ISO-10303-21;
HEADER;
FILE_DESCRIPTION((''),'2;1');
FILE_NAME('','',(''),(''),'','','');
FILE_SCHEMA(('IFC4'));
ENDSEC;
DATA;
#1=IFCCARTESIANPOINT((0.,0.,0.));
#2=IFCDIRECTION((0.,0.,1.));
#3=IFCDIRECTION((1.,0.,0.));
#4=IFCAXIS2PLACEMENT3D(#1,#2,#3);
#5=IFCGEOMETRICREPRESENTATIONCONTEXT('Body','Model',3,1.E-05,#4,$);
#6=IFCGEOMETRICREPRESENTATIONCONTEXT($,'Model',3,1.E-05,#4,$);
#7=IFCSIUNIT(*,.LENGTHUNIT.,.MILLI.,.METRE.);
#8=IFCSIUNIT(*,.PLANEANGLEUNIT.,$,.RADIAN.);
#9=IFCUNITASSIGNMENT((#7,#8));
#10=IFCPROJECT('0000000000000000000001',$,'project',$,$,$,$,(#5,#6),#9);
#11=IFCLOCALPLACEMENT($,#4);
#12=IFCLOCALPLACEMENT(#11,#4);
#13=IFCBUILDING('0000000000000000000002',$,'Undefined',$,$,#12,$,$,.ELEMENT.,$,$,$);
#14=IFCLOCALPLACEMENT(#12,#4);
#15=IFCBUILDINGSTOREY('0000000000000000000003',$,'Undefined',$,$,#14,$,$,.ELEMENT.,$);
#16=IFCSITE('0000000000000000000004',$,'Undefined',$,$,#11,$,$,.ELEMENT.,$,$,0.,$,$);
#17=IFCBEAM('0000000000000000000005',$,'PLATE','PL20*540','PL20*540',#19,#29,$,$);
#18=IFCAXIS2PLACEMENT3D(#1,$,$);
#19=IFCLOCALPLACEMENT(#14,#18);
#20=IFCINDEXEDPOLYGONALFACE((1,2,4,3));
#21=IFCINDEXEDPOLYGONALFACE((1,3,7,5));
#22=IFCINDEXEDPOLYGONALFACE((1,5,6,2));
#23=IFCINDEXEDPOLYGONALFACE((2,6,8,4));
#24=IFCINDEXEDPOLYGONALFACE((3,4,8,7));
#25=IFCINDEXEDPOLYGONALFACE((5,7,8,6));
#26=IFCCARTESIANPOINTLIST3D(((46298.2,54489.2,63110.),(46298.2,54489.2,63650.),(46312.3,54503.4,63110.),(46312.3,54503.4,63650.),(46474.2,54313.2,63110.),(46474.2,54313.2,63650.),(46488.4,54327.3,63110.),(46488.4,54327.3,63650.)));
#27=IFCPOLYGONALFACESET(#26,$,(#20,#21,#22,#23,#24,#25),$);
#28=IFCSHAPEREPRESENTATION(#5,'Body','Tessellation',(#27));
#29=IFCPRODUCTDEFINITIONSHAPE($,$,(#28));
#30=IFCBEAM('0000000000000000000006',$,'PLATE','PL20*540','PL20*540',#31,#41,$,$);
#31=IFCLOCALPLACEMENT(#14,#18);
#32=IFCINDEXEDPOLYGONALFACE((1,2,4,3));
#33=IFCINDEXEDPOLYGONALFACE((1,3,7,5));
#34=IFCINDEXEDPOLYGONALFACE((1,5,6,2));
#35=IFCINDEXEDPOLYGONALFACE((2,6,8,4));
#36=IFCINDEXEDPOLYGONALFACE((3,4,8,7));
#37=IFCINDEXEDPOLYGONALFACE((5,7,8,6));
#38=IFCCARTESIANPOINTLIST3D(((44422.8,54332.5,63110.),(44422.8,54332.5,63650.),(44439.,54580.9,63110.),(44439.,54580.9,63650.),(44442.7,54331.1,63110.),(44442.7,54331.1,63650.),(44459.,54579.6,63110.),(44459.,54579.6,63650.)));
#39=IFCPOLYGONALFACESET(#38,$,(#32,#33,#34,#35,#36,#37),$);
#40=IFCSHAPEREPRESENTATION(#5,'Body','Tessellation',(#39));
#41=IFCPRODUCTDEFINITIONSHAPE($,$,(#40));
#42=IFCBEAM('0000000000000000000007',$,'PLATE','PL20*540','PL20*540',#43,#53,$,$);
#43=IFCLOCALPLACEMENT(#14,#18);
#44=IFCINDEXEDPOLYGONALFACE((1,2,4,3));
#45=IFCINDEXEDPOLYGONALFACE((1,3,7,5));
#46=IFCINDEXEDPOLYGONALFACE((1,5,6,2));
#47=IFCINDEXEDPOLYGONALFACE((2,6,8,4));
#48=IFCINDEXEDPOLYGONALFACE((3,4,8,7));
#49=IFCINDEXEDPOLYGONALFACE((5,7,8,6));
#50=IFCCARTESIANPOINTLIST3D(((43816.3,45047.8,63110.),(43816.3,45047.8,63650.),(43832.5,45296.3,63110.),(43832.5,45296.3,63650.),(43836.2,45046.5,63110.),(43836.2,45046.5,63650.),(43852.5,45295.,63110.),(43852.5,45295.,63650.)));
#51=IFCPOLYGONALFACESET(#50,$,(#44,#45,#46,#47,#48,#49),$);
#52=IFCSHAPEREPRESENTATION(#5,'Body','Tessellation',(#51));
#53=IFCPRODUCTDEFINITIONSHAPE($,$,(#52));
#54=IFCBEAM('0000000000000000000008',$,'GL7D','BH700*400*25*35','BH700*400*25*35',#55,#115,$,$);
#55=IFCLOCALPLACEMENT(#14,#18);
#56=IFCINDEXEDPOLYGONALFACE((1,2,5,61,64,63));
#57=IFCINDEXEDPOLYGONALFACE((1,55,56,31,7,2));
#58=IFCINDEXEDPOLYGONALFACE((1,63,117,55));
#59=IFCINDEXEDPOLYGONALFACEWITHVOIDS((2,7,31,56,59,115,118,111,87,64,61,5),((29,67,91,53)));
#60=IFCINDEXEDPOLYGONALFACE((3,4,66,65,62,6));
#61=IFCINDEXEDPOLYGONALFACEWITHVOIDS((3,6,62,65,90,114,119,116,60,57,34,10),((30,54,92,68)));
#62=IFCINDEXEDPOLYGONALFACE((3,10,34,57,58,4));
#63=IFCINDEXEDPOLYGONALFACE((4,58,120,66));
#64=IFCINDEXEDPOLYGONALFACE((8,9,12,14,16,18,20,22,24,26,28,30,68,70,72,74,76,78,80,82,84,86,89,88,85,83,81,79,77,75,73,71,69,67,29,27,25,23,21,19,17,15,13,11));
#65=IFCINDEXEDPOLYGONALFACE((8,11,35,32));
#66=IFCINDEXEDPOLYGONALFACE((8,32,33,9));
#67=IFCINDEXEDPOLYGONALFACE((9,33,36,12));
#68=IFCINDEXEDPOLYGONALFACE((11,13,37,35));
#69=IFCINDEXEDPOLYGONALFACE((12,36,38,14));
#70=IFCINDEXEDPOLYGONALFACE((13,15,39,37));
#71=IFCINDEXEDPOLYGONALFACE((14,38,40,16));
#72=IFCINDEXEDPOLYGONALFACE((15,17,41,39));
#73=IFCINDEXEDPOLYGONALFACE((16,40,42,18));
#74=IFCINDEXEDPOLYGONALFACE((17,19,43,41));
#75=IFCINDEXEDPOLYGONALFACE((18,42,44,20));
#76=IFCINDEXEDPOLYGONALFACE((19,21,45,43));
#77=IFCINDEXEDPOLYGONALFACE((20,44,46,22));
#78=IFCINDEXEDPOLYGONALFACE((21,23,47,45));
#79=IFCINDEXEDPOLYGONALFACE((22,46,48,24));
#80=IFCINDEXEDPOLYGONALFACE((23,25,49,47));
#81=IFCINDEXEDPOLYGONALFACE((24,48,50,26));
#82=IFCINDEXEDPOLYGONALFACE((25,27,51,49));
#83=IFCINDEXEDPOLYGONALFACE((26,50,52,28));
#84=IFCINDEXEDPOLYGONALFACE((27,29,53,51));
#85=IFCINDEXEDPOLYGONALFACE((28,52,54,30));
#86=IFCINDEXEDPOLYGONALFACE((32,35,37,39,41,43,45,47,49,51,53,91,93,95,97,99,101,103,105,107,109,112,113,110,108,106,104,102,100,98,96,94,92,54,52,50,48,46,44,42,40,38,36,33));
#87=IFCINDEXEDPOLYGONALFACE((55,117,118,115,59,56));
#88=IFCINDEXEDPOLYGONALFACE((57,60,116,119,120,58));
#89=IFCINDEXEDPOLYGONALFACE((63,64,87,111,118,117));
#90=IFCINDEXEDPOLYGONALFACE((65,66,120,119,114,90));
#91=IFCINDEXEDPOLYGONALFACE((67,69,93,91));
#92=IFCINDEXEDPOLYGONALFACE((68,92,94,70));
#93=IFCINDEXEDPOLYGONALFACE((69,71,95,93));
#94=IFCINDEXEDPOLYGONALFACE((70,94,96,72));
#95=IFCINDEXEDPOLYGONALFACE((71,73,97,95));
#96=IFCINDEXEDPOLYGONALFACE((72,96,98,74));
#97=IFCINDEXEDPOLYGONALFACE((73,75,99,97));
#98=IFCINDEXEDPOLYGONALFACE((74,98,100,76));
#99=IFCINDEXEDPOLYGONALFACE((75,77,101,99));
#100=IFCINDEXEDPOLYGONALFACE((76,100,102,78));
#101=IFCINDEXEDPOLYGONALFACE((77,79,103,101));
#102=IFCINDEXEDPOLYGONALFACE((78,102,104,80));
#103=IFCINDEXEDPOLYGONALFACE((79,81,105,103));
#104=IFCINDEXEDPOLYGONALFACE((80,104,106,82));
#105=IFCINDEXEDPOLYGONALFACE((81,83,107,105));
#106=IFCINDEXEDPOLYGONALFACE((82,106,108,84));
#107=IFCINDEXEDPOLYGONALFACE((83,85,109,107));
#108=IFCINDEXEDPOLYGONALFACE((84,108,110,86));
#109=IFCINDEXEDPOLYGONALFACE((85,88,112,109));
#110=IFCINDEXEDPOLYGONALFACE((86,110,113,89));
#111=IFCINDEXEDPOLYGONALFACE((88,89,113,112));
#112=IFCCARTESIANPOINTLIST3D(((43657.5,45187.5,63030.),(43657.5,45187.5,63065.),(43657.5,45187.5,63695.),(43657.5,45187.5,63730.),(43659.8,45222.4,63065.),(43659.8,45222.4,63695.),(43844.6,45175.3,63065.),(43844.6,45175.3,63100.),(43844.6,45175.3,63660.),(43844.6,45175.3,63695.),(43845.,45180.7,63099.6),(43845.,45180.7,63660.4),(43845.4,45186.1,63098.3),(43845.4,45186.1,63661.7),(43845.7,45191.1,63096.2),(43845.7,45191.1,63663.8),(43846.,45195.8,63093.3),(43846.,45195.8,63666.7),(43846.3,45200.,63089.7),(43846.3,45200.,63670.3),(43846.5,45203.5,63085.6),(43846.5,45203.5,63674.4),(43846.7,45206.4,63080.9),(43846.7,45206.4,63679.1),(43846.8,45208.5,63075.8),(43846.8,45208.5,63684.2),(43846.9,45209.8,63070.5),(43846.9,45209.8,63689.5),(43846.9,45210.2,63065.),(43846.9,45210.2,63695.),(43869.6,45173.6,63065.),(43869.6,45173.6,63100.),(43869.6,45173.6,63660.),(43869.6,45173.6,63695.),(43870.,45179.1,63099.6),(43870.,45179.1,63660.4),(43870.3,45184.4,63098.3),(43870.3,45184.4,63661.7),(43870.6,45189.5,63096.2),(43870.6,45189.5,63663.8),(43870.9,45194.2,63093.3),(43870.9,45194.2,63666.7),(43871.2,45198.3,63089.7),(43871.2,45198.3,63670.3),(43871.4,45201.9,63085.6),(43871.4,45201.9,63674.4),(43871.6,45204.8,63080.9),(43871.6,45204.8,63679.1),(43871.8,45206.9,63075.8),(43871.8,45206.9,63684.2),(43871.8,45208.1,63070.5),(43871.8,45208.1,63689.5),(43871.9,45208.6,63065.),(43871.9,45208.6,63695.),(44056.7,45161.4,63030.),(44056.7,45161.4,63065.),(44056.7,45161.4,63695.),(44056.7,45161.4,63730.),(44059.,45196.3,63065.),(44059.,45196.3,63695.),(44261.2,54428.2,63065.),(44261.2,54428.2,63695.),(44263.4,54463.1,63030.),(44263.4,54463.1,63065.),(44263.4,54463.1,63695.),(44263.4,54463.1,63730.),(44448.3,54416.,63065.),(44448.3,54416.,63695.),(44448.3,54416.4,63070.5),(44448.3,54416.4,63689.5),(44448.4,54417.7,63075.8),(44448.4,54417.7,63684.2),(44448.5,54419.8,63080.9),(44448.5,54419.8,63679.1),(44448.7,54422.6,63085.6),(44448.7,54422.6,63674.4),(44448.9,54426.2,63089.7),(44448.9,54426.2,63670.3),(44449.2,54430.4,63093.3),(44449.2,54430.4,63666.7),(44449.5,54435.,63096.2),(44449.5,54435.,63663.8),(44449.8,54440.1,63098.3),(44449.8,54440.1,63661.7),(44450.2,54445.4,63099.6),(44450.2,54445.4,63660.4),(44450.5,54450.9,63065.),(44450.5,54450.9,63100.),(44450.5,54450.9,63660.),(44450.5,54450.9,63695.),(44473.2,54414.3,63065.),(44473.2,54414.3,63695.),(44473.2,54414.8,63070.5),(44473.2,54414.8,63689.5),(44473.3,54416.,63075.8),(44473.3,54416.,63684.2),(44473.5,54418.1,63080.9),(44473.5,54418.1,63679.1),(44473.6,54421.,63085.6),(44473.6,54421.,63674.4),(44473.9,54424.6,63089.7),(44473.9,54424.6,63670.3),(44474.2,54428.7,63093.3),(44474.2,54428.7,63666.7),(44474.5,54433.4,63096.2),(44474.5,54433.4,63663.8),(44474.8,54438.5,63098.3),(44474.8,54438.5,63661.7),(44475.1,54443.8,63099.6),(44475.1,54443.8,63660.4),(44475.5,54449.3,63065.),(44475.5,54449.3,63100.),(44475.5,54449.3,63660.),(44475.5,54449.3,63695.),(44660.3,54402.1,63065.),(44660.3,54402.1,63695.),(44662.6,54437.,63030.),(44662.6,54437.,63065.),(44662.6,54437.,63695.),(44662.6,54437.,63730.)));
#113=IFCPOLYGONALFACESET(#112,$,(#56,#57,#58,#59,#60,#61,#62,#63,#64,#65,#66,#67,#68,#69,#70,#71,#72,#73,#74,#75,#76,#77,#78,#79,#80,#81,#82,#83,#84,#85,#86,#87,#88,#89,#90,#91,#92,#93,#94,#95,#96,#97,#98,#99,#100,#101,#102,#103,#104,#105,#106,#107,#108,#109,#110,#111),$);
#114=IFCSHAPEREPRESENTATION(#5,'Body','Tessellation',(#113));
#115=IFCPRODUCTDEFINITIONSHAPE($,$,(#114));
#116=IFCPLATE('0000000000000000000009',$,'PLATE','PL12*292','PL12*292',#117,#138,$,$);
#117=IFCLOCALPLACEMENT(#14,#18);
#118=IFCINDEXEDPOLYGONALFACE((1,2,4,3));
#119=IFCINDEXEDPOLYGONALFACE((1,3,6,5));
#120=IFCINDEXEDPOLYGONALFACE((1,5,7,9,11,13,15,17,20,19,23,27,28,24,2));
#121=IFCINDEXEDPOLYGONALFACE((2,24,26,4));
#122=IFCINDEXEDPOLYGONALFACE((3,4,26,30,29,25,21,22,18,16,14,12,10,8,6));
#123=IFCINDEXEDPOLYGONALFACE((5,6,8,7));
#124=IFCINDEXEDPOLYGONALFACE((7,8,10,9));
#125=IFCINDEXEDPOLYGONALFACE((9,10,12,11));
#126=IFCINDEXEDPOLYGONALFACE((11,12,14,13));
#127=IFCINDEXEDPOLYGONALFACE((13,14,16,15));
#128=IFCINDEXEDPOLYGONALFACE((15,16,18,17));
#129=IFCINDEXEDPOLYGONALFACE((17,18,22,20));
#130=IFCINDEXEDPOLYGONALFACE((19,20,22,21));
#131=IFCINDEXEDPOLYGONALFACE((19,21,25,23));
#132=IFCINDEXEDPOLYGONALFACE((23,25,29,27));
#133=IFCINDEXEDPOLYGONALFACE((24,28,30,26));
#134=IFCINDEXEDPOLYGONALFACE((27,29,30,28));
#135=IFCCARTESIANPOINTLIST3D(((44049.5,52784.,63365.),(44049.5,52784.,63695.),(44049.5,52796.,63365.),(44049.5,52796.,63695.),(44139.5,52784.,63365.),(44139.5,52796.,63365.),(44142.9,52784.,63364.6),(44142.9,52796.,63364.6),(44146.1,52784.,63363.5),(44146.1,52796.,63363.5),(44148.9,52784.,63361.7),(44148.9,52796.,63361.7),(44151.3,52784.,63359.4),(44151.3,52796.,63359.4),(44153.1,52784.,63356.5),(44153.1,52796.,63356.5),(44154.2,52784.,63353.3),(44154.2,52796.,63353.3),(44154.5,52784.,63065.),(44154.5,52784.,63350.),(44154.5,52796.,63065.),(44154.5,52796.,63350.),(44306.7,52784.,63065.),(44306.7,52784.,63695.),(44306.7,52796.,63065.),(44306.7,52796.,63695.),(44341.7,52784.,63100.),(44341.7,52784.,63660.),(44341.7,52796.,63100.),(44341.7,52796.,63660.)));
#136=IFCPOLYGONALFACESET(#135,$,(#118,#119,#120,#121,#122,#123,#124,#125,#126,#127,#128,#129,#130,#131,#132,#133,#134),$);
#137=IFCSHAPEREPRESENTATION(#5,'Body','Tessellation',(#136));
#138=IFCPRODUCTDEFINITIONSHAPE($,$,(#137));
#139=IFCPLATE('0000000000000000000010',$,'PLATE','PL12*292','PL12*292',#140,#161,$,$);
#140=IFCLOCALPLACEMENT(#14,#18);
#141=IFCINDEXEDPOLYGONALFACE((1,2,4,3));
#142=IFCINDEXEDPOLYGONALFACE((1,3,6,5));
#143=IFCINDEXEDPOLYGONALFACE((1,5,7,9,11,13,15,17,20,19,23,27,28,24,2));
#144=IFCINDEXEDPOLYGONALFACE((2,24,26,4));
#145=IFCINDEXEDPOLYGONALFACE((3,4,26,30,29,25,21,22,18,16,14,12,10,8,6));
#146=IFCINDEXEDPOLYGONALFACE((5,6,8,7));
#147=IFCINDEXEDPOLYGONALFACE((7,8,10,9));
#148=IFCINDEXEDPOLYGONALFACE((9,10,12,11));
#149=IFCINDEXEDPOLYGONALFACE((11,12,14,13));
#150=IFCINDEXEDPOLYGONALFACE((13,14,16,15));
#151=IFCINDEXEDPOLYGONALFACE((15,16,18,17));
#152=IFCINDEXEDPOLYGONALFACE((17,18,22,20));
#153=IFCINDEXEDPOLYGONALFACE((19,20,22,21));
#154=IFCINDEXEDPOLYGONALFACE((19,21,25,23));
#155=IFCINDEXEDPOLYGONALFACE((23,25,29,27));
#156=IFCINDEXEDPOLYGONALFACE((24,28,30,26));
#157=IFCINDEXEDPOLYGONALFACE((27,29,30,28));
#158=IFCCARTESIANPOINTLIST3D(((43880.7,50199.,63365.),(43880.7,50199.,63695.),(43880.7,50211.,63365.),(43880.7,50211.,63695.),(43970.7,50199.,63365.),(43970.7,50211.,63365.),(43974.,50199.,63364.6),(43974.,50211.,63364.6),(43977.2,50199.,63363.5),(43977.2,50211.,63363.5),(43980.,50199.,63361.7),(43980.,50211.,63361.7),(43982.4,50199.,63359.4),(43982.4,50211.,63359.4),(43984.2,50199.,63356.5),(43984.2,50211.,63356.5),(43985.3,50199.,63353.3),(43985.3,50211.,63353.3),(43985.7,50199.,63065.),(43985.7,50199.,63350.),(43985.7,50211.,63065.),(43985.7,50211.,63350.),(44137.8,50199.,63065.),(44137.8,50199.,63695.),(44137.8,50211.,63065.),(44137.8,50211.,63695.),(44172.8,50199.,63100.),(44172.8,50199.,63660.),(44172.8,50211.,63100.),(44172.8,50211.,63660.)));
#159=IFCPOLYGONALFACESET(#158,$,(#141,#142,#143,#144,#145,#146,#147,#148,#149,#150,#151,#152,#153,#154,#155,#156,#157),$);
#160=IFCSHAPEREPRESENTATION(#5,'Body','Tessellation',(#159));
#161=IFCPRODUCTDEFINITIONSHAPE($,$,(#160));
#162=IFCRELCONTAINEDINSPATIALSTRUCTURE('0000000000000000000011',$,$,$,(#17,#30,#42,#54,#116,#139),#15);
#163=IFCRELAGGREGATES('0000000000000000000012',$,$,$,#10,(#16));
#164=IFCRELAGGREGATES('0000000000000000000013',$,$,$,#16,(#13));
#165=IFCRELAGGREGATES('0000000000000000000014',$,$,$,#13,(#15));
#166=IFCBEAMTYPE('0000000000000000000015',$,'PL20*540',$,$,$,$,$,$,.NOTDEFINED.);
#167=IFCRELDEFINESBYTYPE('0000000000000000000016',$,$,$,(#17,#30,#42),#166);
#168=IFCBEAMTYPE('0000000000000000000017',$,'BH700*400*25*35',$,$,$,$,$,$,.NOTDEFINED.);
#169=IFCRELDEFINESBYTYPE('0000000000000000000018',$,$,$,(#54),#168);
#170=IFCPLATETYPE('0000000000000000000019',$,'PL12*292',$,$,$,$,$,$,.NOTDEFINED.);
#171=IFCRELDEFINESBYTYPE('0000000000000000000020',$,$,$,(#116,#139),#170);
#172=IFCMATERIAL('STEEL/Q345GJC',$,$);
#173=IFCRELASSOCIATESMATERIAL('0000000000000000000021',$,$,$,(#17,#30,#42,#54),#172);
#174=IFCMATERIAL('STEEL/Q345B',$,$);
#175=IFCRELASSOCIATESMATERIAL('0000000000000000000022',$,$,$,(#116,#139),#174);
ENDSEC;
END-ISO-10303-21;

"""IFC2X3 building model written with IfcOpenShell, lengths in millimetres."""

from ifc_helpers import new_model, si_unit, frame, origin_with_axes, origin_2d_with_axis, place, context, project, spatial, polyline, rectangle, i_section, outline, extrude, material, type_object, element, save


model = new_model("IFC2X3")

# Units and contexts
model_context_1 = context("Model", 3, precision=1e-05, world=origin_with_axes(), identifier="Body")
model_context_2 = context("Model", 3, precision=1e-05, world=origin_with_axes())
ifc_project = project(units=[si_unit("LENGTHUNIT", "METRE", prefix="MILLI"), si_unit("PLANEANGLEUNIT", "RADIAN")], contexts=[model_context_1, model_context_2])

# Site, building, storey
site_placement = place(None, origin_with_axes())
site = spatial("IfcSite", under=ifc_project, at=site_placement, Name="Undefined", CompositionType="ELEMENT", RefElevation=0.0)
building_placement = place(site_placement, origin_with_axes())
building = spatial("IfcBuilding", under=site, at=building_placement, Name="Undefined", CompositionType="ELEMENT")
storey_placement = place(building_placement, origin_with_axes())
storey = spatial("IfcBuildingStorey", under=building, at=storey_placement, Name="Undefined", CompositionType="ELEMENT")

# Beams
ifc_material_1 = material(Name="STEEL/Q345B")
ifc_material_2 = material(Name="STEEL/Q345GJC")
beam_type_1 = type_object("IfcBeamType", Name="PL20*540", PredefinedType="NOTDEFINED")
beam_1_placement = place(storey_placement, frame((46305.2, 54496.3, 63380.0), z_axis=(0.0, 0.0, 1.0), x_axis=(0.707107, -0.707107, 0.0)))
element("IfcBeam", 1, at=beam_1_placement, inside=storey, type_object=beam_type_1, material=ifc_material_2, Name="PLATE", Description="PL20*540", ObjectType="PL20*540", context=model_context_1, shape_type="SweptSolid", body=[
    extrude(rectangle(XDim=20.0, YDim=540.0, at=origin_2d_with_axis()), frame((249.0, 0.0, 0.0), z_axis=(-1.0, 0.0, 0.0), x_axis=(0.0, -1.0, 0.0)), (0.0, 0.0, 1.0), 249.0),
])
for number, where, z_axis, x_axis, name in (
    (2, (44449.0, 54580.3, 63380.0), (0.0, 0.0, 1.0), (-0.065183, -0.997873, 0.0), "PLATE"),
    (3, (43826.3, 45047.2, 63380.0), (0.0, 0.0, 1.0), (0.065184, 0.997873, 0.0), "PLATE"),
):
    element("IfcBeam", number, at=place(storey_placement, frame(where, z_axis=z_axis, x_axis=x_axis)), inside=storey, type_object=beam_type_1, material=ifc_material_2, Name=name, Description="PL20*540", ObjectType="PL20*540", context=model_context_1, shape_type="SweptSolid", body=[
        extrude(rectangle(XDim=20.0, YDim=540.0, at=origin_2d_with_axis()), frame((249.0, 0.0, 0.0), z_axis=(-1.0, 0.0, 0.0), x_axis=(0.0, -1.0, 0.0)), (0.0, 0.0, 1.0), 249.0),
    ])

# Beam, openings
beam_type_2 = type_object("IfcBeamType", Name="BH700*400*25*35", PredefinedType="NOTDEFINED")
beam_2_placement = place(storey_placement, frame((44523.0, 55367.7, 63380.0), z_axis=(0.0, 0.0, 1.0), x_axis=(-0.065183, -0.997873, 0.0)))
beam_2 = element("IfcBeam", 4, at=beam_2_placement, inside=storey, type_object=beam_type_2, material=ifc_material_2, Name="GL7D", Description="BH700*400*25*35", ObjectType="BH700*400*25*35", context=model_context_1, shape_type="SweptSolid", body=[
    extrude(i_section(OverallWidth=400.0, OverallDepth=700.0, WebThickness=25.0, FlangeThickness=35.0, at=origin_2d_with_axis()), frame((10215.0, 0.0, 0.0), z_axis=(-1.0, 0.0, 0.0), x_axis=(0.0, -1.0, 0.0)), (0.0, 0.0, 1.0), 9295.4),
])
opening_1_placement = place(storey_placement, frame((44523.0, 55367.7, 63380.0), z_axis=(0.0, 0.0, 1.0), x_axis=(-0.065183, -0.997873, 0.0)))
element("IfcOpeningElement", 5, at=opening_1_placement, cuts=beam_2, ObjectType="Recess", context=model_context_1, shape_type="SweptSolid", body=[
    extrude(outline(polyline([(0.0, 0.0), (37.0, 0.0), (37.0, 35.0), (35.0, 35.0), (29.5, 34.6), (24.2, 33.3), (19.1, 31.2), (14.4, 28.3), (10.3, 24.7), (6.7, 20.6), (3.8, 15.9), (1.7, 10.8), (0.4, 5.5), (0.0, 0.0), (0.0, 0.0)])), frame((10180.0, -200.0, 315.0), z_axis=(0.0, 1.0, 0.0), x_axis=(1.0, 0.0, 0.0)), (0.0, 0.0, 1.0), 400.0),
])
opening_2_placement = place(storey_placement, frame((44523.0, 55367.7, 63380.0), z_axis=(0.0, 0.0, 1.0), x_axis=(-0.065183, -0.997873, 0.0)))
element("IfcOpeningElement", 6, at=opening_2_placement, cuts=beam_2, ObjectType="Recess", context=model_context_1, shape_type="SweptSolid", body=[
    extrude(outline(polyline([(0.0, 0.0), (37.0, 0.0), (36.6, 5.5), (35.3, 10.8), (33.2, 15.9), (30.3, 20.6), (26.7, 24.7), (22.6, 28.3), (17.9, 31.2), (12.8, 33.3), (7.5, 34.6), (2.0, 35.0), (0.0, 35.0), (0.0, 0.0)])), frame((10217.0, -200.0, -315.0), z_axis=(0.0, 1.0, 0.0), x_axis=(-1.0, 0.0, 0.0)), (0.0, 0.0, 1.0), 400.0),
])
opening_3_placement = place(storey_placement, frame((44523.0, 55367.7, 63380.0), z_axis=(0.0, 0.0, 1.0), x_axis=(-0.065183, -0.997873, 0.0)))
element("IfcOpeningElement", 7, at=opening_3_placement, cuts=beam_2, ObjectType="Recess", context=model_context_1, shape_type="SweptSolid", body=[
    extrude(outline(polyline([(0.0, 0.0), (37.0, 0.0), (37.0, 35.0), (35.0, 35.0), (29.5, 34.6), (24.2, 33.3), (19.1, 31.2), (14.4, 28.3), (10.3, 24.7), (6.7, 20.6), (3.8, 15.9), (1.7, 10.8), (0.4, 5.5), (0.0, 0.0), (0.0, 0.0)])), frame((954.6, 200.0, 315.0), z_axis=(0.0, -1.0, 0.0), x_axis=(-1.0, 0.0, 0.0)), (0.0, 0.0, 1.0), 400.0),
])
opening_4_placement = place(storey_placement, frame((44523.0, 55367.7, 63380.0), z_axis=(0.0, 0.0, 1.0), x_axis=(-0.065183, -0.997873, 0.0)))
element("IfcOpeningElement", 8, at=opening_4_placement, cuts=beam_2, ObjectType="Recess", context=model_context_1, shape_type="SweptSolid", body=[
    extrude(outline(polyline([(0.0, 0.0), (37.0, 0.0), (36.6, 5.5), (35.3, 10.8), (33.2, 15.9), (30.3, 20.6), (26.7, 24.7), (22.6, 28.3), (17.9, 31.2), (12.8, 33.3), (7.5, 34.6), (2.0, 35.0), (0.0, 35.0), (0.0, 0.0)])), frame((917.6, 200.0, -315.0), z_axis=(0.0, -1.0, 0.0), x_axis=(1.0, 0.0, 0.0)), (0.0, 0.0, 1.0), 400.0),
])

# Plates
plate_type_1 = type_object("IfcPlateType", Name="PL12*292", PredefinedType="NOTDEFINED")
for number, where, z_axis, x_axis, name in (
    (9, (44049.5, 52790.0, 63695.0), (0.0, -1.0, 0.0), (0.0, 0.0, -1.0), "PLATE"),
    (10, (43880.7, 50205.0, 63695.0), (0.0, -1.0, 0.0), (0.0, 0.0, -1.0), "PLATE"),
):
    element("IfcPlate", number, at=place(storey_placement, frame(where, z_axis=z_axis, x_axis=x_axis)), inside=storey, type_object=plate_type_1, material=ifc_material_1, Name=name, Description="PL12*292", ObjectType="PL12*292", context=model_context_1, shape_type="SweptSolid", body=[
        extrude(outline(polyline([(0.0, 0.0), (330.0, 0.0), (330.0, 90.0), (330.4, 93.4), (331.5, 96.5), (333.3, 99.4), (335.6, 101.8), (338.5, 103.5), (341.7, 104.7), (345.0, 105.0), (630.0, 105.0), (630.0, 257.1), (595.0, 292.1), (35.0, 292.1), (0.0, 257.1), (0.0, 0.0)])), frame((0.0, 0.0, -6.0), z_axis=(0.0, 0.0, 1.0), x_axis=(1.0, 0.0, 0.0)), (0.0, 0.0, 1.0), 12.0),
    ])

save(model, "model.ifc")
